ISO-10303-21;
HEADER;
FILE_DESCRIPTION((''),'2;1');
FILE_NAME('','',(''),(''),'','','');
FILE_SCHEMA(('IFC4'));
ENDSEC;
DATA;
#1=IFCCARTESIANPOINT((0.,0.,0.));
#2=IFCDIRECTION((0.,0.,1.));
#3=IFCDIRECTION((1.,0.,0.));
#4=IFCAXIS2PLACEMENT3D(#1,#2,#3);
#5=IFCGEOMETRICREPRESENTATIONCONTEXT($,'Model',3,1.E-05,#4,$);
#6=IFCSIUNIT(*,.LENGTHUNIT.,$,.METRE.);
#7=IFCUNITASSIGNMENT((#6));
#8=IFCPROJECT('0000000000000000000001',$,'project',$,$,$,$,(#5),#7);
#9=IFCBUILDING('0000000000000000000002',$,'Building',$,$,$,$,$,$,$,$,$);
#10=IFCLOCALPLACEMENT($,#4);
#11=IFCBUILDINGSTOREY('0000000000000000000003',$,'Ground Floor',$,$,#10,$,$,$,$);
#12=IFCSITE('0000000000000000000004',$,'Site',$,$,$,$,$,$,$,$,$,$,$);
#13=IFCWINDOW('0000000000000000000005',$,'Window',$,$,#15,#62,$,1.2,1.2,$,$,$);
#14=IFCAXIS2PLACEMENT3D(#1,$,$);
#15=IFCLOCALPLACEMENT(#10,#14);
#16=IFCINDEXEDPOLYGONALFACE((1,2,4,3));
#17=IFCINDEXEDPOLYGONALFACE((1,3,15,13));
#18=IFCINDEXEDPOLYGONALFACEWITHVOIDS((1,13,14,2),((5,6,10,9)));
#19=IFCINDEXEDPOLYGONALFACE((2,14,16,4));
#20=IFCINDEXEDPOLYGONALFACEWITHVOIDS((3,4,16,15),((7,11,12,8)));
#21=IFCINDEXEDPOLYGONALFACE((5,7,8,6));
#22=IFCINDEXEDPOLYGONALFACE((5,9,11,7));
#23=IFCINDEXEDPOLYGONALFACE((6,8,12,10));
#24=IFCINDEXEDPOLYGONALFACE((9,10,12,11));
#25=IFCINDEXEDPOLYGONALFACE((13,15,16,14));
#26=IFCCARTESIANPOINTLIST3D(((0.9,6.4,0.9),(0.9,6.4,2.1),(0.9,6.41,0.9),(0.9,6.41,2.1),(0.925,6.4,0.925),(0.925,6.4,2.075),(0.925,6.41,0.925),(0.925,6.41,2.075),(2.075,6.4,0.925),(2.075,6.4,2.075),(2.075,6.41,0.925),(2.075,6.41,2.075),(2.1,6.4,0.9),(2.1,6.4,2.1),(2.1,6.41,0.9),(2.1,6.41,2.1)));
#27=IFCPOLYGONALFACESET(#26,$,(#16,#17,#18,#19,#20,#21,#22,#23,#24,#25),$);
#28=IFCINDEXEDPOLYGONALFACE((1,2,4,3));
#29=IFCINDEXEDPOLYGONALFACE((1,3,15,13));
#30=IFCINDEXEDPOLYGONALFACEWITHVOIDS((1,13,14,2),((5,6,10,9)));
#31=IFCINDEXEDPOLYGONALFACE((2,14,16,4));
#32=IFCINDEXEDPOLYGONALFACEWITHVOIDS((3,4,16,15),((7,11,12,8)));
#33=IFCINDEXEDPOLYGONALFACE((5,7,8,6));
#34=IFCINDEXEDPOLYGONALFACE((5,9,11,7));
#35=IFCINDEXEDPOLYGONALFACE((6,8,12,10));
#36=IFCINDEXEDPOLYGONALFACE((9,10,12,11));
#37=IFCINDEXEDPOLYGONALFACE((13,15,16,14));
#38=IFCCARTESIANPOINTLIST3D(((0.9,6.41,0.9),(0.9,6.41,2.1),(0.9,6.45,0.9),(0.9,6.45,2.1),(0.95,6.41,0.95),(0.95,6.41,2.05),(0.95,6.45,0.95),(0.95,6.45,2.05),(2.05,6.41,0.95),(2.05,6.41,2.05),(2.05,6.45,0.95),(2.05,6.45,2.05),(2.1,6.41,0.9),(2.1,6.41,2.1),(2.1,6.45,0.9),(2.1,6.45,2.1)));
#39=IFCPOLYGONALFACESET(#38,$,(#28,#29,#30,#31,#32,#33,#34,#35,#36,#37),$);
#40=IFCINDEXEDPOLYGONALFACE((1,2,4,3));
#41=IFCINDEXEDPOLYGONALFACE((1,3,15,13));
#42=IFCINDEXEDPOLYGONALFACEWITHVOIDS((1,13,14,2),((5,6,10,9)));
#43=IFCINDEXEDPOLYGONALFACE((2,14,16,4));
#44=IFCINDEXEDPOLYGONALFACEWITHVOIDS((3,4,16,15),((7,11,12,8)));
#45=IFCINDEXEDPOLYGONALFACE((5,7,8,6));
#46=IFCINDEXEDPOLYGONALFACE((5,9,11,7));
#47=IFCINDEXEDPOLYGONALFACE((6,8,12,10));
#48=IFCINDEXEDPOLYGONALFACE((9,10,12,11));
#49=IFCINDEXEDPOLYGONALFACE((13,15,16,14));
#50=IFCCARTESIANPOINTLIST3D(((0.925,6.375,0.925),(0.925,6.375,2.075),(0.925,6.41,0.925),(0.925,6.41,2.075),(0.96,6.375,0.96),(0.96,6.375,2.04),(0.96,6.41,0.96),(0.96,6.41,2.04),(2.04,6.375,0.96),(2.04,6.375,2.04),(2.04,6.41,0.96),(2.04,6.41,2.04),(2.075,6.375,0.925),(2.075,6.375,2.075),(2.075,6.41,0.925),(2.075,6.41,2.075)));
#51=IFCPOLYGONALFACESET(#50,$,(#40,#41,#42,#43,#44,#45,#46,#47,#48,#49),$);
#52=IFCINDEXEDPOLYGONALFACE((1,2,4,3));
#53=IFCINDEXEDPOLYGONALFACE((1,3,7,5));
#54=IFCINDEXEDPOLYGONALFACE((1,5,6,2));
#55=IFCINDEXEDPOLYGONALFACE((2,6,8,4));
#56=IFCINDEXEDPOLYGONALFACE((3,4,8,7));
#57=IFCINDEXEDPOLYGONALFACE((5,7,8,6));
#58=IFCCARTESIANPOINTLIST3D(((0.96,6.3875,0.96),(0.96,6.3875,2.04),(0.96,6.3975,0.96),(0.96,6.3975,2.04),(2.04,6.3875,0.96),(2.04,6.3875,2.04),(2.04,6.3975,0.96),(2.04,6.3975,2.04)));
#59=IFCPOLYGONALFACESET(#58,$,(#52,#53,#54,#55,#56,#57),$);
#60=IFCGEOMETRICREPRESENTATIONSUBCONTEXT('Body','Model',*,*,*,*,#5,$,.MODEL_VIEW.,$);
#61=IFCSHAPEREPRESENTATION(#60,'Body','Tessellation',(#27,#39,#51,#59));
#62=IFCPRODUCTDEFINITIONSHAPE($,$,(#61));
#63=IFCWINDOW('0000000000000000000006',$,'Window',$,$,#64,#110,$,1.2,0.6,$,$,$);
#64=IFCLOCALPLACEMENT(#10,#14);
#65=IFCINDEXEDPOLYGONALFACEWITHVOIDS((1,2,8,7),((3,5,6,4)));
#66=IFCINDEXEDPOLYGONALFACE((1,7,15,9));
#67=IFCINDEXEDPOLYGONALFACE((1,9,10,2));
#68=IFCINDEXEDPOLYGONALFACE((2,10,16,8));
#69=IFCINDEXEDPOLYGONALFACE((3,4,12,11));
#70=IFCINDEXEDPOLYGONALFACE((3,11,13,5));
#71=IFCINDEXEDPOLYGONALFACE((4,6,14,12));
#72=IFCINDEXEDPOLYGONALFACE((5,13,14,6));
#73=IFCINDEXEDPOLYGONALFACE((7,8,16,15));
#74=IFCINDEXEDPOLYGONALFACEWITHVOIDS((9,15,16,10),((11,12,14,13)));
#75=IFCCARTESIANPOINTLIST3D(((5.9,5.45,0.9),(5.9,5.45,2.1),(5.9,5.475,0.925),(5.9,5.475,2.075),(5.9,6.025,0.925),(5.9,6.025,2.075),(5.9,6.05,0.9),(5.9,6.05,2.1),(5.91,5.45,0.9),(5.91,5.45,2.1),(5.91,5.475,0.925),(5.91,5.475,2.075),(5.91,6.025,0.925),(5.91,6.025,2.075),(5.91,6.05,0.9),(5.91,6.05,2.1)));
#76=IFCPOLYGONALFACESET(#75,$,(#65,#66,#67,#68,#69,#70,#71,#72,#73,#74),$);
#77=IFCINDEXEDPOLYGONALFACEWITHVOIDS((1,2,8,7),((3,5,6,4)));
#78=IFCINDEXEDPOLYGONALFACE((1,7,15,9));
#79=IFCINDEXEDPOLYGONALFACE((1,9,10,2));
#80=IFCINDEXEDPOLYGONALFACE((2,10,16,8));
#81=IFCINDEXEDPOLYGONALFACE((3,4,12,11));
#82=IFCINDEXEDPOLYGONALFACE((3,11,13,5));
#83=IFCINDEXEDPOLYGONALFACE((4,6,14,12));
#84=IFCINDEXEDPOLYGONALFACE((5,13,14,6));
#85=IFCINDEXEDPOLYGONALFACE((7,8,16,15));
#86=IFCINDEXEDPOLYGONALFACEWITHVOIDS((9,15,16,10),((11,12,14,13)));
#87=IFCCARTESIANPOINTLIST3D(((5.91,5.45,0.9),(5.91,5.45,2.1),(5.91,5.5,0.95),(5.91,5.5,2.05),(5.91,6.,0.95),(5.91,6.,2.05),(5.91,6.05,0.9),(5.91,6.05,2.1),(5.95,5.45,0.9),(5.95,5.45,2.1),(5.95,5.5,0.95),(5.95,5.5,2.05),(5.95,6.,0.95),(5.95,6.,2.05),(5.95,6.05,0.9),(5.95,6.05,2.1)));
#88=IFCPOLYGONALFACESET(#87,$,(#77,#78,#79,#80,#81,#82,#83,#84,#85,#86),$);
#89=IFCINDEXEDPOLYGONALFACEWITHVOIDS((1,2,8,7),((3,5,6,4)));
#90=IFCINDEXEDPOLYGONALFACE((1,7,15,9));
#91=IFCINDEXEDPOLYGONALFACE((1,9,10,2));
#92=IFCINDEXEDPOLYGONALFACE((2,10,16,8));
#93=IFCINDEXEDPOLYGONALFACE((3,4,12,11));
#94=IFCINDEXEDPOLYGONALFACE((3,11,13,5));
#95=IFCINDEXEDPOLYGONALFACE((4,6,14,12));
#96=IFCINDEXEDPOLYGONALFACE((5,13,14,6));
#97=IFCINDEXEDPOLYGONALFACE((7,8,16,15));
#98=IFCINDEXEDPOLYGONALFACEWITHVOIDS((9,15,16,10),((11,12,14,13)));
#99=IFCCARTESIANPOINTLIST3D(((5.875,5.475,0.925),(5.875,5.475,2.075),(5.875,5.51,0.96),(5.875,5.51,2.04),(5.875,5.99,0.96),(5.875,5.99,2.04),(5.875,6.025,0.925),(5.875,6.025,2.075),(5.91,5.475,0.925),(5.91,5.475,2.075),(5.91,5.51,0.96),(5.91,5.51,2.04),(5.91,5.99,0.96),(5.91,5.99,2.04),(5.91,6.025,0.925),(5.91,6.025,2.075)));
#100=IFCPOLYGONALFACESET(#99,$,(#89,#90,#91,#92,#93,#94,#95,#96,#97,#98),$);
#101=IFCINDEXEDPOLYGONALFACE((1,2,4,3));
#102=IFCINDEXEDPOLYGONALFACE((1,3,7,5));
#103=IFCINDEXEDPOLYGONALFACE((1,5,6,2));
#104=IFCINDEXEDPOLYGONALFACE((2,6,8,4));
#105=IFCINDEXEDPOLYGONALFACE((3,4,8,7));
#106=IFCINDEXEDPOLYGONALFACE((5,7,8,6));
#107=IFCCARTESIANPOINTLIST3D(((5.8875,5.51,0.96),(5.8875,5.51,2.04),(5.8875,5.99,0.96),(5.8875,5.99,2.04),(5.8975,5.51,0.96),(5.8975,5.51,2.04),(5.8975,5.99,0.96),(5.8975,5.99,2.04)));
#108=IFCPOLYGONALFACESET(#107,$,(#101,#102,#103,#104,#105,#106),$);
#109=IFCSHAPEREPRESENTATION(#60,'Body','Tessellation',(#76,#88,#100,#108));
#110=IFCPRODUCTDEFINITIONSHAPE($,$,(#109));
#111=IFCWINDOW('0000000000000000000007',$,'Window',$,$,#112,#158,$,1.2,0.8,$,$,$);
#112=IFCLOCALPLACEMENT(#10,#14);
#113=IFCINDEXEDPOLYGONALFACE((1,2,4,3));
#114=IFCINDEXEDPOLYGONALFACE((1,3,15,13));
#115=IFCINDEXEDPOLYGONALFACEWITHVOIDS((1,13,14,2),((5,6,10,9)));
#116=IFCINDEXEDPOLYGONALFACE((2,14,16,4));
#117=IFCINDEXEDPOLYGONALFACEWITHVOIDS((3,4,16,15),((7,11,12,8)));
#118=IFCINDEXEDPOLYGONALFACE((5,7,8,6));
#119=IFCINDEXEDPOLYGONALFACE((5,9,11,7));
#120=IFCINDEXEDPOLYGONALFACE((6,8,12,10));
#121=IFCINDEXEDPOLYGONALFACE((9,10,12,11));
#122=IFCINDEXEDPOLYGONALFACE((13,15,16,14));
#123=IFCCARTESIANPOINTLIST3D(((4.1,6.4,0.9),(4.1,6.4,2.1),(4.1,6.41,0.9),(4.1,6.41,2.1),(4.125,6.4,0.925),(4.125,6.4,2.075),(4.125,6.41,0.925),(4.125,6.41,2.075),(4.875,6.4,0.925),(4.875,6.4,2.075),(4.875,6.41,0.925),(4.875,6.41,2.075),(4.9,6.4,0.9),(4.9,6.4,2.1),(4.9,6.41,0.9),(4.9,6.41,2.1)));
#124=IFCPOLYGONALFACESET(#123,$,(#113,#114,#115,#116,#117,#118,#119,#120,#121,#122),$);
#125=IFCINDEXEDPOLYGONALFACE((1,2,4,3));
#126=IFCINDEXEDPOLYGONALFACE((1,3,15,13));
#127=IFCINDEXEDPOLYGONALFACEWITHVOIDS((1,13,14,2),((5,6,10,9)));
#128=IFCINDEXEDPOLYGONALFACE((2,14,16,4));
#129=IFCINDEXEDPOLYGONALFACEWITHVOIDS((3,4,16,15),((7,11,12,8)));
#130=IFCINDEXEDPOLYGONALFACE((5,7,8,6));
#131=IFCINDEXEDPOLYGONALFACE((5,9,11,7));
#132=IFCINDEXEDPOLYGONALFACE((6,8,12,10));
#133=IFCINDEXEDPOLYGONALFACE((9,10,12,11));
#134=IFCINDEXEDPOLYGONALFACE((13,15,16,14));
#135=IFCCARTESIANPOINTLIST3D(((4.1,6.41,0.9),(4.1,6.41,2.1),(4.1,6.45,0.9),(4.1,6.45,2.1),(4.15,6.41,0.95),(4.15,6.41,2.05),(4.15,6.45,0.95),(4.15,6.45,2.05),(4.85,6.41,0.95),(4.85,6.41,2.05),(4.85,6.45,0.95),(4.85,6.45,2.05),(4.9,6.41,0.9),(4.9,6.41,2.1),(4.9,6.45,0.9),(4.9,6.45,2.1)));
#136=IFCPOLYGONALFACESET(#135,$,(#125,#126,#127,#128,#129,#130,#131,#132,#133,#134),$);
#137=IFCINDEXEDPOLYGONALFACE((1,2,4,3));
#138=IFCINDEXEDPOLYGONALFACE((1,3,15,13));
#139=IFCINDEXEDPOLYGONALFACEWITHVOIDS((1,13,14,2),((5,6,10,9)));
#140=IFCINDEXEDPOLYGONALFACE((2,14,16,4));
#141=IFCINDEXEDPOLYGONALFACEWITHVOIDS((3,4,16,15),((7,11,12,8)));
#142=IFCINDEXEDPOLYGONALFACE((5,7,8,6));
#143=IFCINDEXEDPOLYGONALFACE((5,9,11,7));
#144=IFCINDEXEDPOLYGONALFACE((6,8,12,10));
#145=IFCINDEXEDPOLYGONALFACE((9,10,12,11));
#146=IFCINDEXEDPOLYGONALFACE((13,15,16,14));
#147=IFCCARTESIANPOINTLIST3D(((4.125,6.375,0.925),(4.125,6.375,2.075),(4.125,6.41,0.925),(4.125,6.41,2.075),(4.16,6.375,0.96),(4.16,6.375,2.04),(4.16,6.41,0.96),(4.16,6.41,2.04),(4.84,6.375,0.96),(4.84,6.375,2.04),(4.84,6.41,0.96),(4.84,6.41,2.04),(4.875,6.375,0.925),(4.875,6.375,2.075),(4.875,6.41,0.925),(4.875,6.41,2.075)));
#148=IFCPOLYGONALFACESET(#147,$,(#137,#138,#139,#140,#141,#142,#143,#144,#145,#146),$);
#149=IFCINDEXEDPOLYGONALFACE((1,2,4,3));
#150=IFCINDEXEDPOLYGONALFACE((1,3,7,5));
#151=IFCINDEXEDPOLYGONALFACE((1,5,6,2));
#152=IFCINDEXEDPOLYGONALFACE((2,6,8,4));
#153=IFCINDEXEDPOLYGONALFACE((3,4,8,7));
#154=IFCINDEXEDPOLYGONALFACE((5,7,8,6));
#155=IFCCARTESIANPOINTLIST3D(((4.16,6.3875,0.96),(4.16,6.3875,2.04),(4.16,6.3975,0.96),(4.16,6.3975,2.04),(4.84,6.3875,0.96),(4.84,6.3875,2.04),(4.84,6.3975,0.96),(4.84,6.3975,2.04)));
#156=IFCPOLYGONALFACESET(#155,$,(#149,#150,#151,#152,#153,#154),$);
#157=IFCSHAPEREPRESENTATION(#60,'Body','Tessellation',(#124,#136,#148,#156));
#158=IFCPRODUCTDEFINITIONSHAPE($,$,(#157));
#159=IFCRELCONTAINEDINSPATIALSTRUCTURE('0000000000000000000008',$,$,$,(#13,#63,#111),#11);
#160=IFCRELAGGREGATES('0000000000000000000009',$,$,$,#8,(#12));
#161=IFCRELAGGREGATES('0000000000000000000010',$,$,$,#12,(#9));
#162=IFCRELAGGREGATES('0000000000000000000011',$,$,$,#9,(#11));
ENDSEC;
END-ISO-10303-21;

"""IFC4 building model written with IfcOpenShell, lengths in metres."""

from ifc_helpers import new_model, si_unit, frame, origin_with_axes, place, context, subcontext, project, spatial, line, indexed_curve, outline, extrude, element, save


model = new_model("IFC4")

# Units and contexts
model_context = context("Model", 3, precision=1e-05, world=origin_with_axes())
body_context = subcontext(model_context, "Body", "Model", "MODEL_VIEW")
ifc_project = project(units=[si_unit("LENGTHUNIT", "METRE")], contexts=[model_context])

# Site, building, storey
site = spatial("IfcSite", under=ifc_project, Name="Site")
building = spatial("IfcBuilding", under=site, Name="Building")
storey_placement = place(None, origin_with_axes())
storey = spatial("IfcBuildingStorey", under=building, at=storey_placement, Name="Ground Floor")

# Windows
window_1_placement = place(storey_placement, frame((2.1, 6.5, 0.9), z_axis=(0.0, 0.0, 1.0), x_axis=(-1.0, 0.0, 0.0)))
element("IfcWindow", 1, at=window_1_placement, inside=storey, Name="Window", OverallHeight=1.2, OverallWidth=1.2, context=body_context, shape_type="SweptSolid", body=[
    extrude(outline(indexed_curve([(0.0, 0.0), (1.2, 0.0), (1.2, 1.2), (0.0, 1.2)], segments=[line(1, 2, 3, 4, 1)]), holes=[indexed_curve([(0.025, 0.025), (1.175, 0.025), (1.175, 1.175), (0.025, 1.175)], segments=[line(1, 2, 3, 4, 1)])]), frame((0.0, 0.09, 0.0), z_axis=(0.0, -1.0, 0.0), x_axis=(1.0, 0.0, 0.0)), (0.0, 0.0, -1.0), 0.01),
    extrude(outline(indexed_curve([(0.0, 0.0), (1.2, 0.0), (1.2, 1.2), (0.0, 1.2)], segments=[line(1, 2, 3, 4, 1)]), holes=[indexed_curve([(0.05, 0.05), (1.15, 0.05), (1.15, 1.15), (0.05, 1.15)], segments=[line(1, 2, 3, 4, 1)])]), frame((0.0, 0.05, 0.0), z_axis=(0.0, -1.0, 0.0), x_axis=(1.0, 0.0, 0.0)), (0.0, 0.0, -1.0), 0.04),
    extrude(outline(indexed_curve([(0.0, 0.0), (1.15, 0.0), (1.15, 1.15), (0.0, 1.15)], segments=[line(1, 2, 3, 4, 1)]), holes=[indexed_curve([(0.035, 0.035), (1.115, 0.035), (1.115, 1.115), (0.035, 1.115)], segments=[line(1, 2, 3, 4, 1)])]), frame((0.025, 0.09, 0.025), z_axis=(0.0, -1.0, 0.0), x_axis=(1.0, 0.0, 0.0)), (0.0, 0.0, -1.0), 0.035),
    extrude(outline(indexed_curve([(0.035, 0.035), (1.115, 0.035), (1.115, 1.115), (0.035, 1.115)], segments=[line(1, 2, 3, 4, 1)])), frame((0.025, 0.1025, 0.025), z_axis=(0.0, -1.0, 0.0), x_axis=(1.0, 0.0, 0.0)), (0.0, 0.0, -1.0), 0.01),
])
window_2_placement = place(storey_placement, frame((6.0, 5.45, 0.9), z_axis=(0.0, 0.0, 1.0), x_axis=(0.0, 1.0, 0.0)))
element("IfcWindow", 2, at=window_2_placement, inside=storey, Name="Window", OverallHeight=1.2, OverallWidth=0.6, context=body_context, shape_type="SweptSolid", body=[
    extrude(outline(indexed_curve([(0.0, 0.0), (0.6, 0.0), (0.6, 1.2), (0.0, 1.2)], segments=[line(1, 2, 3, 4, 1)]), holes=[indexed_curve([(0.025, 0.025), (0.575, 0.025), (0.575, 1.175), (0.025, 1.175)], segments=[line(1, 2, 3, 4, 1)])]), frame((0.0, 0.09, 0.0), z_axis=(0.0, -1.0, 0.0), x_axis=(1.0, 0.0, 0.0)), (0.0, 0.0, -1.0), 0.01),
    extrude(outline(indexed_curve([(0.0, 0.0), (0.6, 0.0), (0.6, 1.2), (0.0, 1.2)], segments=[line(1, 2, 3, 4, 1)]), holes=[indexed_curve([(0.05, 0.05), (0.55, 0.05), (0.55, 1.15), (0.05, 1.15)], segments=[line(1, 2, 3, 4, 1)])]), frame((0.0, 0.05, 0.0), z_axis=(0.0, -1.0, 0.0), x_axis=(1.0, 0.0, 0.0)), (0.0, 0.0, -1.0), 0.04),
    extrude(outline(indexed_curve([(0.0, 0.0), (0.55, 0.0), (0.55, 1.15), (0.0, 1.15)], segments=[line(1, 2, 3, 4, 1)]), holes=[indexed_curve([(0.035, 0.035), (0.515, 0.035), (0.515, 1.115), (0.035, 1.115)], segments=[line(1, 2, 3, 4, 1)])]), frame((0.025, 0.09, 0.025), z_axis=(0.0, -1.0, 0.0), x_axis=(1.0, 0.0, 0.0)), (0.0, 0.0, -1.0), 0.035),
    extrude(outline(indexed_curve([(0.035, 0.035), (0.515, 0.035), (0.515, 1.115), (0.035, 1.115)], segments=[line(1, 2, 3, 4, 1)])), frame((0.025, 0.1025, 0.025), z_axis=(0.0, -1.0, 0.0), x_axis=(1.0, 0.0, 0.0)), (0.0, 0.0, -1.0), 0.01),
])
window_3_placement = place(storey_placement, frame((4.9, 6.5, 0.9), z_axis=(0.0, 0.0, 1.0), x_axis=(-1.0, 0.0, 0.0)))
element("IfcWindow", 3, at=window_3_placement, inside=storey, Name="Window", OverallHeight=1.2, OverallWidth=0.8, context=body_context, shape_type="SweptSolid", body=[
    extrude(outline(indexed_curve([(0.0, 0.0), (0.8, 0.0), (0.8, 1.2), (0.0, 1.2)], segments=[line(1, 2, 3, 4, 1)]), holes=[indexed_curve([(0.025, 0.025), (0.775, 0.025), (0.775, 1.175), (0.025, 1.175)], segments=[line(1, 2, 3, 4, 1)])]), frame((0.0, 0.09, 0.0), z_axis=(0.0, -1.0, 0.0), x_axis=(1.0, 0.0, 0.0)), (0.0, 0.0, -1.0), 0.01),
    extrude(outline(indexed_curve([(0.0, 0.0), (0.8, 0.0), (0.8, 1.2), (0.0, 1.2)], segments=[line(1, 2, 3, 4, 1)]), holes=[indexed_curve([(0.05, 0.05), (0.75, 0.05), (0.75, 1.15), (0.05, 1.15)], segments=[line(1, 2, 3, 4, 1)])]), frame((0.0, 0.05, 0.0), z_axis=(0.0, -1.0, 0.0), x_axis=(1.0, 0.0, 0.0)), (0.0, 0.0, -1.0), 0.04),
    extrude(outline(indexed_curve([(0.0, 0.0), (0.75, 0.0), (0.75, 1.15), (0.0, 1.15)], segments=[line(1, 2, 3, 4, 1)]), holes=[indexed_curve([(0.035, 0.035), (0.715, 0.035), (0.715, 1.115), (0.035, 1.115)], segments=[line(1, 2, 3, 4, 1)])]), frame((0.025, 0.09, 0.025), z_axis=(0.0, -1.0, 0.0), x_axis=(1.0, 0.0, 0.0)), (0.0, 0.0, -1.0), 0.035),
    extrude(outline(indexed_curve([(0.035, 0.035), (0.715, 0.035), (0.715, 1.115), (0.035, 1.115)], segments=[line(1, 2, 3, 4, 1)])), frame((0.025, 0.1025, 0.025), z_axis=(0.0, -1.0, 0.0), x_axis=(1.0, 0.0, 0.0)), (0.0, 0.0, -1.0), 0.01),
])

save(model, "model.ifc")
